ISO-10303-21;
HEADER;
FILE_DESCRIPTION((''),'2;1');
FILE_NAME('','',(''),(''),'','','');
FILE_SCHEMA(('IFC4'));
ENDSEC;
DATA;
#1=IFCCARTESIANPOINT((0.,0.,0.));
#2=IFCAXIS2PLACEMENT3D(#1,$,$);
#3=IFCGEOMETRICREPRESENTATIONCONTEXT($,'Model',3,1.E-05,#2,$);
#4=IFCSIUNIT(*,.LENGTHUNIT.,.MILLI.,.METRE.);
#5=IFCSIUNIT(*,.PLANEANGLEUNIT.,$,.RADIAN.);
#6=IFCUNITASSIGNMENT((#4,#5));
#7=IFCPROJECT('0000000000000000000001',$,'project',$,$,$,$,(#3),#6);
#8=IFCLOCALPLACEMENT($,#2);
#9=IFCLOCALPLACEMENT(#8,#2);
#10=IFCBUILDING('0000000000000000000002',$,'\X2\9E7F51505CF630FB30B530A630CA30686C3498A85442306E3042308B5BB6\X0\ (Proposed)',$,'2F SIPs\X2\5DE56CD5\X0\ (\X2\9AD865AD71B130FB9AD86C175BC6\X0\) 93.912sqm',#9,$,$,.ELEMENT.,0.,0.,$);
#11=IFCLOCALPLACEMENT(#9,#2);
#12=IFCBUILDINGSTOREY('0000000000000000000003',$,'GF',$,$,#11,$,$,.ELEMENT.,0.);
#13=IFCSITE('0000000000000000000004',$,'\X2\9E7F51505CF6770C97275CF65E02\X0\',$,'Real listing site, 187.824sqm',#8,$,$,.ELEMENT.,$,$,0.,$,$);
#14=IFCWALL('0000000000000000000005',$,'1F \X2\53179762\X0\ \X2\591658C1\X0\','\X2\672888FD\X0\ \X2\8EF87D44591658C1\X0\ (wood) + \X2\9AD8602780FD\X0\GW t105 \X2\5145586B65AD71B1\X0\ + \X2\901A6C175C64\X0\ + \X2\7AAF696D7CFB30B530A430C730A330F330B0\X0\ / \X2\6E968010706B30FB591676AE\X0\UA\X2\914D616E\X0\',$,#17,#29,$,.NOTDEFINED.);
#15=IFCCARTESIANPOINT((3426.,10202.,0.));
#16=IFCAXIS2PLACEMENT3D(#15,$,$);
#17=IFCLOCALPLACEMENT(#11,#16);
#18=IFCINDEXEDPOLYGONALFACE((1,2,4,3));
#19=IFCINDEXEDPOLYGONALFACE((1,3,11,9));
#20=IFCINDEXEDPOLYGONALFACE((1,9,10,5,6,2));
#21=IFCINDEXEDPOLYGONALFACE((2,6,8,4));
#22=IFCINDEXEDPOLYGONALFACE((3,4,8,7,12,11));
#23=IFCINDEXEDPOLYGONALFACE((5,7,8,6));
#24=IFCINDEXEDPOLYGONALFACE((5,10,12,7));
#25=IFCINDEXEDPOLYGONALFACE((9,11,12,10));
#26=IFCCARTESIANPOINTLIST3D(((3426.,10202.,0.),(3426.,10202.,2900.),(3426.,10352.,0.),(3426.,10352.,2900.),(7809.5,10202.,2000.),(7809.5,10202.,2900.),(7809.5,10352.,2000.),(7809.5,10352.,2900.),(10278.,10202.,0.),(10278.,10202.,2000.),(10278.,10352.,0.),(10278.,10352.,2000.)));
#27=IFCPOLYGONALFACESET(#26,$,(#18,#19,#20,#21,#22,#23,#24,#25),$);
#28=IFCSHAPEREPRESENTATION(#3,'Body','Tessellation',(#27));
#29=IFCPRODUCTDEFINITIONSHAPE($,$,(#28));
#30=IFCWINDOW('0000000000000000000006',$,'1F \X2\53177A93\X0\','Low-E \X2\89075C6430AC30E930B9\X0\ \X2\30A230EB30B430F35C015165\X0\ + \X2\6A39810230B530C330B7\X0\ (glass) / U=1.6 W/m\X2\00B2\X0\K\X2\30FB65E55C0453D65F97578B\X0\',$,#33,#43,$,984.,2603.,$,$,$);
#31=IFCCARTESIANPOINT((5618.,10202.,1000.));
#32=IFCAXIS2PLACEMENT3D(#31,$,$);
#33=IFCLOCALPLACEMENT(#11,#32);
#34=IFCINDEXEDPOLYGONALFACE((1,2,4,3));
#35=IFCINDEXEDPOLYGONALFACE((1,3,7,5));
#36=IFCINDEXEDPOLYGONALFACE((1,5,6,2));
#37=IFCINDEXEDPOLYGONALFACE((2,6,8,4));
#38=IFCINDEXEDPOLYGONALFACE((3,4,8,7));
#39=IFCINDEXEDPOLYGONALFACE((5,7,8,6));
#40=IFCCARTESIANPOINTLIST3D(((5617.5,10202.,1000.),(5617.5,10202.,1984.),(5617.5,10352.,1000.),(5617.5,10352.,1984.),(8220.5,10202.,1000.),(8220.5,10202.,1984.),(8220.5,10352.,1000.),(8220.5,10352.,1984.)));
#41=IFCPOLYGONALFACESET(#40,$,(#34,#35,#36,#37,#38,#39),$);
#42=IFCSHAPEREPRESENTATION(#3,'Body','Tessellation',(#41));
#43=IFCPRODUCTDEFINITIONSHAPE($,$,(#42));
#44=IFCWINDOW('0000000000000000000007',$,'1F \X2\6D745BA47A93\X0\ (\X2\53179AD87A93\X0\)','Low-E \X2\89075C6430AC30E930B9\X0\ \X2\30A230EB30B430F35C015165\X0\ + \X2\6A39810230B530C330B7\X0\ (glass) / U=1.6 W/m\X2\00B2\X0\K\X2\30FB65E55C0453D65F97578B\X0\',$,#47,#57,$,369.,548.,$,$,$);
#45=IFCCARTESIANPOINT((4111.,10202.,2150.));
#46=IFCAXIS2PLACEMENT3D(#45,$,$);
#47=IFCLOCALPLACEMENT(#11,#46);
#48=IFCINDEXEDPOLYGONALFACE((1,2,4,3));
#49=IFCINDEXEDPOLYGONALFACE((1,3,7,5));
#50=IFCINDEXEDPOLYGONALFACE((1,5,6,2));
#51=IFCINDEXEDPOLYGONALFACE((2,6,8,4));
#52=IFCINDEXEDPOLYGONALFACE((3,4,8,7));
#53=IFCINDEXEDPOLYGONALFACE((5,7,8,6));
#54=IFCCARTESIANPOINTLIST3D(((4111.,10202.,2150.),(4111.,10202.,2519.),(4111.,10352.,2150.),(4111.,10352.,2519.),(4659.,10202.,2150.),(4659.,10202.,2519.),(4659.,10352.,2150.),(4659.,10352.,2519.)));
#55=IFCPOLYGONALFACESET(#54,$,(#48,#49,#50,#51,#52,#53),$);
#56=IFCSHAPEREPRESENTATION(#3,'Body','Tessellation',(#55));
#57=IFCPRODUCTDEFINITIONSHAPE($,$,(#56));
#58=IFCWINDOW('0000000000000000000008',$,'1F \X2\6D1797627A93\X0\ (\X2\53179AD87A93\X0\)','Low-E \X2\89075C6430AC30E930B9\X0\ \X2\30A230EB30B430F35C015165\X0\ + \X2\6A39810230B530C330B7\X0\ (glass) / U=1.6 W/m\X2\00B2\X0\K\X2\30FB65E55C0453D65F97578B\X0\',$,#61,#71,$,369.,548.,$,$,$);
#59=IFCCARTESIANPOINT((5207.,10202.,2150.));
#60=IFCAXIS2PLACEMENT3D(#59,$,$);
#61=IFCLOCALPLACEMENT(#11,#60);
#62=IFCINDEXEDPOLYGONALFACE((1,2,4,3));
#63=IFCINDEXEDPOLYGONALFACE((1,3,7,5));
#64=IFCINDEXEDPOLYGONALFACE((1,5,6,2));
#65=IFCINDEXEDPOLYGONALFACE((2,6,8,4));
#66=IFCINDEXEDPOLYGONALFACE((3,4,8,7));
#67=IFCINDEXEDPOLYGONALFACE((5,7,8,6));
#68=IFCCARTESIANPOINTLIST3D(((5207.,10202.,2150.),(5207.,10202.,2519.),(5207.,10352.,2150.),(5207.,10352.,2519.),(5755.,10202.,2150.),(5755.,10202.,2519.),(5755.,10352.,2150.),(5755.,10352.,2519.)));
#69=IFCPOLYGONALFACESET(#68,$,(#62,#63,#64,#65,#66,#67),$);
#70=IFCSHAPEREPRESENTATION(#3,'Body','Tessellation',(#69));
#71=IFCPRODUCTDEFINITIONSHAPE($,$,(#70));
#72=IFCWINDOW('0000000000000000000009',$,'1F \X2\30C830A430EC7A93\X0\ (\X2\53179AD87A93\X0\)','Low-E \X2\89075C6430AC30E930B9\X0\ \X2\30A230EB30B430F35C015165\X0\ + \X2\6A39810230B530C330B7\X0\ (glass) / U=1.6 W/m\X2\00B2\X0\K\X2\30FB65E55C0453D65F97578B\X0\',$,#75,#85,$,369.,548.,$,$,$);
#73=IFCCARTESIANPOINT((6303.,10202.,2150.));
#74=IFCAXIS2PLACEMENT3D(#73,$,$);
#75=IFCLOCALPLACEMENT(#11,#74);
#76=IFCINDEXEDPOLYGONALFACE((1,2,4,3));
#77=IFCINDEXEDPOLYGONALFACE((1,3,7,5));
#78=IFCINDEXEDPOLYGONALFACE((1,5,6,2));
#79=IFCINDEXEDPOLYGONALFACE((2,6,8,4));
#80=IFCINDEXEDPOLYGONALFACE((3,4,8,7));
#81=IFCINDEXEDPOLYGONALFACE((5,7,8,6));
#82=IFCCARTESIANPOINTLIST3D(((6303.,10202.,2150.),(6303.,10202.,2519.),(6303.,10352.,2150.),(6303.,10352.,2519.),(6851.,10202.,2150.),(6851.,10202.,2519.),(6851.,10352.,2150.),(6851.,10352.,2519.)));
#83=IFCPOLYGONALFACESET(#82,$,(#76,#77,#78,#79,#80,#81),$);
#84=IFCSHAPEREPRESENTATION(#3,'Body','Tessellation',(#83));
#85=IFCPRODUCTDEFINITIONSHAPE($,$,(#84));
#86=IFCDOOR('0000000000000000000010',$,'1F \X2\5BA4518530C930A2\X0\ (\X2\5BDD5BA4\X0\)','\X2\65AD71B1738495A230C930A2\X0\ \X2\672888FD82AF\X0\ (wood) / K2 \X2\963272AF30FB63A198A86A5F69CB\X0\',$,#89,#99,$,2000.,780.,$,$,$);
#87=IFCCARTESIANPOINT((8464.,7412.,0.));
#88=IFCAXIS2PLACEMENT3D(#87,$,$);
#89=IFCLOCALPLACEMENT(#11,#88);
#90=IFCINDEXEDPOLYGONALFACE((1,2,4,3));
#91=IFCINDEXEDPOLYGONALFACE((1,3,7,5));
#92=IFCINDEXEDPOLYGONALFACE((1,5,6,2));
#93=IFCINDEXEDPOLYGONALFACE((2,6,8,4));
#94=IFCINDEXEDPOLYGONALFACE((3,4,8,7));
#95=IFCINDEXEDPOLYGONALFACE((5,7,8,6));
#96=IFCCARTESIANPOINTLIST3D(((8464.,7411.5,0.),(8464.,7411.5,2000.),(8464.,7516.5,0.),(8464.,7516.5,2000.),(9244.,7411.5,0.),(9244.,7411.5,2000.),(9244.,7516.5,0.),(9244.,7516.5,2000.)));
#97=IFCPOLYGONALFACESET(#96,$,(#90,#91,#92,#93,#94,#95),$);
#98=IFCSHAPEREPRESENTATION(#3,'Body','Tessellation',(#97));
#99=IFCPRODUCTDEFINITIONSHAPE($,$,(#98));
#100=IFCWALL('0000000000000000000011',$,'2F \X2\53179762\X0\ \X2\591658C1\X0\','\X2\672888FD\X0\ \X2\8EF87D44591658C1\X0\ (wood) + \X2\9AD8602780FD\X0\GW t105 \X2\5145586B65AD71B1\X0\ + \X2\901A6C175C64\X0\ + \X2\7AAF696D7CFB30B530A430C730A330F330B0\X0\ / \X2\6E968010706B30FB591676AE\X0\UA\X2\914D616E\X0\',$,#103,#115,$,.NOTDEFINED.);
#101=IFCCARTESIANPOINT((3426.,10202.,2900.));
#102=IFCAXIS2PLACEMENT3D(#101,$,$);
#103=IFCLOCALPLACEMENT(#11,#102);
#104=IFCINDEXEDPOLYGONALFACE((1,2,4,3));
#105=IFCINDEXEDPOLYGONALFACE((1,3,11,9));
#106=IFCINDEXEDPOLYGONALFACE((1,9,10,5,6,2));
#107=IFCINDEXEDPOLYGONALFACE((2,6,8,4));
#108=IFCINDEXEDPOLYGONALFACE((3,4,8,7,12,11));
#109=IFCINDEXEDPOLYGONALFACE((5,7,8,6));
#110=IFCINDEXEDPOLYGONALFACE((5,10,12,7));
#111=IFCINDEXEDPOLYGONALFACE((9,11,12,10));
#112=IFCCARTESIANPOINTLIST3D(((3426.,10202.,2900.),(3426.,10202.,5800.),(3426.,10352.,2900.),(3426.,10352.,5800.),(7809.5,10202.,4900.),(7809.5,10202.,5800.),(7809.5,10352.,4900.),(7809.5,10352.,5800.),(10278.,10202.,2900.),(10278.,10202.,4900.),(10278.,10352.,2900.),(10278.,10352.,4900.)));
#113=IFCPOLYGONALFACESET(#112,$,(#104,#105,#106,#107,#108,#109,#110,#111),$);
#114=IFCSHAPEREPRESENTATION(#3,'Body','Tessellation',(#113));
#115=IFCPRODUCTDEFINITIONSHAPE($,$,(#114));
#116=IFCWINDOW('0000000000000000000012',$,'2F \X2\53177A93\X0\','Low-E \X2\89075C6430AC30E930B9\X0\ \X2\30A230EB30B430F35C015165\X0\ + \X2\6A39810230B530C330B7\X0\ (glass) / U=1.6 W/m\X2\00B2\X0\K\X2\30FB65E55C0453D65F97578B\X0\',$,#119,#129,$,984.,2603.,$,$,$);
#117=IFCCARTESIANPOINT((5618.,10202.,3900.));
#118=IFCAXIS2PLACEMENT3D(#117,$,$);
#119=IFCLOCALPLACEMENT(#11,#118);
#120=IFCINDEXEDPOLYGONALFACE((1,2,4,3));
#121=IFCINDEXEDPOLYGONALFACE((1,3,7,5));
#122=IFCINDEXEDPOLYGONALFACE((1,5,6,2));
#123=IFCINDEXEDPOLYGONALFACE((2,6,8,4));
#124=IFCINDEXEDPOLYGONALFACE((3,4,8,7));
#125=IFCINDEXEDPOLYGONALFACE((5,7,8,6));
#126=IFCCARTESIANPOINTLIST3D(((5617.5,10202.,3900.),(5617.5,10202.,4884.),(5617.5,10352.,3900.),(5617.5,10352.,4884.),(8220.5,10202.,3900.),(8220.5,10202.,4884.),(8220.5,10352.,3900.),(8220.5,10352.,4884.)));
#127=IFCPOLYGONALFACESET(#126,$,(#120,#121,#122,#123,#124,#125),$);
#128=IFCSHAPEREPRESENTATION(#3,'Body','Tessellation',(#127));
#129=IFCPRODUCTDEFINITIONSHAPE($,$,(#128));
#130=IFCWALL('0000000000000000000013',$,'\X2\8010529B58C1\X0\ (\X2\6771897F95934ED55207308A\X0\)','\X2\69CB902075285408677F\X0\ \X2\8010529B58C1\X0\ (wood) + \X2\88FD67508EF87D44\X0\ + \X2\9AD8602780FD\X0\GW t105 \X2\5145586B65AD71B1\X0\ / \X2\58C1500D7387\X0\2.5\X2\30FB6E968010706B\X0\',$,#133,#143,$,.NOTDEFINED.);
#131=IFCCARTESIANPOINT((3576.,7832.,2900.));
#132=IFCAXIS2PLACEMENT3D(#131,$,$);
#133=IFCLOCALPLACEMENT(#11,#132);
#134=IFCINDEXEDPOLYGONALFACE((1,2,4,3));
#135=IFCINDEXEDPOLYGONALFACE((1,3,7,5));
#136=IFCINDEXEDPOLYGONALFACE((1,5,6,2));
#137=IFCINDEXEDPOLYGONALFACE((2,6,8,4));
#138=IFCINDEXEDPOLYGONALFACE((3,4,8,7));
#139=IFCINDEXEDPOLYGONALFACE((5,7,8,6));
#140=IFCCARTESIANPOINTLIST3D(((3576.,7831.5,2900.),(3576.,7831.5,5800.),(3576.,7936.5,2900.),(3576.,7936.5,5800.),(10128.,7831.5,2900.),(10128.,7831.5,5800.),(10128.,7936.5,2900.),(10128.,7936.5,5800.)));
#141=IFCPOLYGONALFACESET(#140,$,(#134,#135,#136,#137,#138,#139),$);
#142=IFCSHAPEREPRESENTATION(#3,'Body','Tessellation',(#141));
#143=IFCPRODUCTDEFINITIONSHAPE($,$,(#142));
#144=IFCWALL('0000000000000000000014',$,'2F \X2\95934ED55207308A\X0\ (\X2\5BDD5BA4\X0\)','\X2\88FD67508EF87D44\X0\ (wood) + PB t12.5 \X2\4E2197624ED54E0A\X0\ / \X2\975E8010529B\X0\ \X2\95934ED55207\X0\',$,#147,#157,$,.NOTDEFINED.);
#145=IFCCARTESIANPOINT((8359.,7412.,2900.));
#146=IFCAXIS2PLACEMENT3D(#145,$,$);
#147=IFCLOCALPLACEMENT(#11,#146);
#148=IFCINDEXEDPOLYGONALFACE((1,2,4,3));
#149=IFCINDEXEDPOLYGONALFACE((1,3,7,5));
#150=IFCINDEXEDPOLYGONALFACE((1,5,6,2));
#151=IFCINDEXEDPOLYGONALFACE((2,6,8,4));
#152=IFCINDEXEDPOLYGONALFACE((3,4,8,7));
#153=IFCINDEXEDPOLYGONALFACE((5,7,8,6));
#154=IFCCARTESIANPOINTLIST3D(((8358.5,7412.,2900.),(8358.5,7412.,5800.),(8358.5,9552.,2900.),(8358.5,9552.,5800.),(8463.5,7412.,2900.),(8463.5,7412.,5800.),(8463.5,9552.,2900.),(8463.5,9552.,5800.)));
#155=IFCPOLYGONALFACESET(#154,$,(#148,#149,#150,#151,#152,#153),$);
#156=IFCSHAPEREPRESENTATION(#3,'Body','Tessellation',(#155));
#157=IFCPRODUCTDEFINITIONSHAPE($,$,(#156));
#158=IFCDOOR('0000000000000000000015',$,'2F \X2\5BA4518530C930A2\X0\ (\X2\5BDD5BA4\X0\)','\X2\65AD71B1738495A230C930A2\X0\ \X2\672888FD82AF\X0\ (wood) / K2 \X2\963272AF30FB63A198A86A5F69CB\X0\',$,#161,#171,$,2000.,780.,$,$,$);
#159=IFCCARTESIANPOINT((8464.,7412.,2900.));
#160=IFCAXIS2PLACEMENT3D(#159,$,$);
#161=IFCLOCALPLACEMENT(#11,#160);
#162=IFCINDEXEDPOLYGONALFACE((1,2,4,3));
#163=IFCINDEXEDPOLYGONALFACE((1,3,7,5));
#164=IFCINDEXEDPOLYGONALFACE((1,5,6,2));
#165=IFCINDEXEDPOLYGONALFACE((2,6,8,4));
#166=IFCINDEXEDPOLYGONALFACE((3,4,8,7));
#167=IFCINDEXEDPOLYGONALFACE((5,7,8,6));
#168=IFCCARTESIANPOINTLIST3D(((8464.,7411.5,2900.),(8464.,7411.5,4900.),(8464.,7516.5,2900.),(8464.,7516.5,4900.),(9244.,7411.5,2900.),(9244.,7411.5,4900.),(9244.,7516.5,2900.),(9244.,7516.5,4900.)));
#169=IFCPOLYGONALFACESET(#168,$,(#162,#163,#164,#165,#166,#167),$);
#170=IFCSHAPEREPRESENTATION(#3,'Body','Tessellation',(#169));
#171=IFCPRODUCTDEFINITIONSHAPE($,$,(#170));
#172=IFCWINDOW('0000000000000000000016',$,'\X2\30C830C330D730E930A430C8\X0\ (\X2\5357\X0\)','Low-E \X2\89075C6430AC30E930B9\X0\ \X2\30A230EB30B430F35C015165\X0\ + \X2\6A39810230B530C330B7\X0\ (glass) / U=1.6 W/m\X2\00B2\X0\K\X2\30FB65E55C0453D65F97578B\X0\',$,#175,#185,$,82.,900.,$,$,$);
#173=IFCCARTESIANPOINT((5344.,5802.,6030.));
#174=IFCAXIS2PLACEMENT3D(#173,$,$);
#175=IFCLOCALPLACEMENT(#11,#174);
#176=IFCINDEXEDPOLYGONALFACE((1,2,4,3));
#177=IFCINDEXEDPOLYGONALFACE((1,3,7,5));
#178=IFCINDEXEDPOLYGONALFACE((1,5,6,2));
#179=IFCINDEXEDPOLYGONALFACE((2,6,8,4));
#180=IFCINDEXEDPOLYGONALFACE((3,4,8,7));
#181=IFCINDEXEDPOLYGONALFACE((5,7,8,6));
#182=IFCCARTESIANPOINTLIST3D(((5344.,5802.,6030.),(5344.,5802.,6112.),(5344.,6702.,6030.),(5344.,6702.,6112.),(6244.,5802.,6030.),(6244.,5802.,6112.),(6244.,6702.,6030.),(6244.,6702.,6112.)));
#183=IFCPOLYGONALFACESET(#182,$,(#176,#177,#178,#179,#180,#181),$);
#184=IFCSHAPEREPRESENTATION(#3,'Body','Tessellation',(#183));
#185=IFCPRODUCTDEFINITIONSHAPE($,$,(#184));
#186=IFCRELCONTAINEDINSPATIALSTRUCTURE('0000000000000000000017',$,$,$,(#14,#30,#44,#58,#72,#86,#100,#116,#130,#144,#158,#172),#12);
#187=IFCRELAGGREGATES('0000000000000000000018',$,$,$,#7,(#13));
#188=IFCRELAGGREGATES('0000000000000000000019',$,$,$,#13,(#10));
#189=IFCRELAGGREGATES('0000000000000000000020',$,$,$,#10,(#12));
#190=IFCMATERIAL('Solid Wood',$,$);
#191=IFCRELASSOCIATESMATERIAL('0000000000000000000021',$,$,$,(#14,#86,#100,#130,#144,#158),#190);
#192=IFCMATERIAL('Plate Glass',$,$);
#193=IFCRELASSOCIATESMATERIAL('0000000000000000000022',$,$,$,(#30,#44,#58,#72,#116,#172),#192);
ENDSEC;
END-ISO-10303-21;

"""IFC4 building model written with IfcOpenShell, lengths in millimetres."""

from ifc_helpers import new_model, si_unit, frame, frame_2d, origin, place, context, project, spatial, rectangle, extrude, material, element, fill, save


model = new_model("IFC4")

# Units and contexts
model_context = context("Model", 3, precision=1e-05, world=origin())
ifc_project = project(units=[si_unit("LENGTHUNIT", "METRE", prefix="MILLI"), si_unit("PLANEANGLEUNIT", "RADIAN")], contexts=[model_context])

# Site, building, storey
site_placement = place(None, origin())
site = spatial("IfcSite", under=ifc_project, at=site_placement, Name="鹿児島県霧島市", ObjectType="Real listing site, 187.824sqm", CompositionType="ELEMENT", RefElevation=0.0)
building_placement = place(site_placement, origin())
building = spatial("IfcBuilding", under=site, at=building_placement, Name="鹿児島・サウナと水風呂のある家 (Proposed)", ObjectType="2F SIPs工法 (高断熱・高気密) 93.912sqm", CompositionType="ELEMENT", ElevationOfRefHeight=0.0, ElevationOfTerrain=0.0)
storey_placement = place(building_placement, origin())
storey = spatial("IfcBuildingStorey", under=building, at=storey_placement, Name="GF", CompositionType="ELEMENT", Elevation=0.0)

# Wall, openings, windows
ifc_material_1 = material(Name="Solid Wood")
wall_1_placement = place(storey_placement, frame((3426.0, 10202.0, 0.0)))
wall_1 = element("IfcWall", 1, at=wall_1_placement, inside=storey, material=ifc_material_1, Name="1F 北面 外壁", Description="木製 軸組外壁 (wood) + 高性能GW t105 充填断熱 + 通気層 + 窯業系サイディング / 準耐火・外皮UA配慮", PredefinedType="NOTDEFINED", context=model_context, shape_type="SweptSolid", body=[
    extrude(rectangle(XDim=6852.0, YDim=150.0, at=frame_2d((3426.0, 75.0))), frame((3426.0, 10202.0, 0.0)), (0.0, 0.0, 1.0), 2900.0),
])
opening_1_placement = place(storey_placement, frame((5618.0, 10202.0, 1000.0)))
opening_1 = element("IfcOpeningElement", 2, at=opening_1_placement, cuts=wall_1, PredefinedType="NOTDEFINED", context=model_context, shape_type="SweptSolid", body=[
    extrude(rectangle(XDim=2603.0, YDim=150.0, at=frame_2d((1301.0, 75.0))), frame((5618.0, 10202.0, 1000.0)), (0.0, 0.0, 1.0), 984.0),
])
opening_2_placement = place(storey_placement, frame((4111.0, 10202.0, 2150.0)))
opening_2 = element("IfcOpeningElement", 3, at=opening_2_placement, cuts=wall_1, PredefinedType="NOTDEFINED", context=model_context, shape_type="SweptSolid", body=[
    extrude(rectangle(XDim=548.0, YDim=150.0, at=frame_2d((274.0, 75.0))), frame((4111.0, 10202.0, 2150.0)), (0.0, 0.0, 1.0), 369.0),
])
opening_3_placement = place(storey_placement, frame((5207.0, 10202.0, 2150.0)))
opening_3 = element("IfcOpeningElement", 4, at=opening_3_placement, cuts=wall_1, PredefinedType="NOTDEFINED", context=model_context, shape_type="SweptSolid", body=[
    extrude(rectangle(XDim=548.0, YDim=150.0, at=frame_2d((274.0, 75.0))), frame((5207.0, 10202.0, 2150.0)), (0.0, 0.0, 1.0), 369.0),
])
opening_4_placement = place(storey_placement, frame((6303.0, 10202.0, 2150.0)))
opening_4 = element("IfcOpeningElement", 5, at=opening_4_placement, cuts=wall_1, PredefinedType="NOTDEFINED", context=model_context, shape_type="SweptSolid", body=[
    extrude(rectangle(XDim=548.0, YDim=150.0, at=frame_2d((274.0, 75.0))), frame((6303.0, 10202.0, 2150.0)), (0.0, 0.0, 1.0), 369.0),
])
ifc_material_2 = material(Name="Plate Glass")
window_1_placement = place(storey_placement, frame((5618.0, 10202.0, 1000.0)))
window_1 = element("IfcWindow", 6, at=window_1_placement, inside=storey, material=ifc_material_2, Name="1F 北窓", Description="Low-E 複層ガラス アルゴン封入 + 樹脂サッシ (glass) / U=1.6 W/m²K・日射取得型", OverallHeight=984.0, OverallWidth=2603.0, context=model_context, shape_type="SweptSolid", body=[
    extrude(rectangle(XDim=2603.0, YDim=150.0, at=frame_2d((1301.0, 75.0))), frame((5618.0, 10202.0, 1000.0)), (0.0, 0.0, 1.0), 984.0),
])
fill(opening_1, window_1)
window_2_placement = place(storey_placement, frame((4111.0, 10202.0, 2150.0)))
window_2 = element("IfcWindow", 7, at=window_2_placement, inside=storey, material=ifc_material_2, Name="1F 浴室窓 (北高窓)", Description="Low-E 複層ガラス アルゴン封入 + 樹脂サッシ (glass) / U=1.6 W/m²K・日射取得型", OverallHeight=369.0, OverallWidth=548.0, context=model_context, shape_type="SweptSolid", body=[
    extrude(rectangle(XDim=548.0, YDim=150.0, at=frame_2d((274.0, 75.0))), frame((4111.0, 10202.0, 2150.0)), (0.0, 0.0, 1.0), 369.0),
])
fill(opening_2, window_2)
window_3_placement = place(storey_placement, frame((5207.0, 10202.0, 2150.0)))
window_3 = element("IfcWindow", 8, at=window_3_placement, inside=storey, material=ifc_material_2, Name="1F 洗面窓 (北高窓)", Description="Low-E 複層ガラス アルゴン封入 + 樹脂サッシ (glass) / U=1.6 W/m²K・日射取得型", OverallHeight=369.0, OverallWidth=548.0, context=model_context, shape_type="SweptSolid", body=[
    extrude(rectangle(XDim=548.0, YDim=150.0, at=frame_2d((274.0, 75.0))), frame((5207.0, 10202.0, 2150.0)), (0.0, 0.0, 1.0), 369.0),
])
fill(opening_3, window_3)
window_4_placement = place(storey_placement, frame((6303.0, 10202.0, 2150.0)))
window_4 = element("IfcWindow", 9, at=window_4_placement, inside=storey, material=ifc_material_2, Name="1F トイレ窓 (北高窓)", Description="Low-E 複層ガラス アルゴン封入 + 樹脂サッシ (glass) / U=1.6 W/m²K・日射取得型", OverallHeight=369.0, OverallWidth=548.0, context=model_context, shape_type="SweptSolid", body=[
    extrude(rectangle(XDim=548.0, YDim=150.0, at=frame_2d((274.0, 75.0))), frame((6303.0, 10202.0, 2150.0)), (0.0, 0.0, 1.0), 369.0),
])
fill(opening_4, window_4)

# Door
door_1_placement = place(storey_placement, frame((8464.0, 7412.0, 0.0)))
element("IfcDoor", 10, at=door_1_placement, inside=storey, material=ifc_material_1, Name="1F 室内ドア (寝室)", Description="断熱玄関ドア 木製芯 (wood) / K2 防犯・採風機構", OverallHeight=2000.0, OverallWidth=780.0, context=model_context, shape_type="SweptSolid", body=[
    extrude(rectangle(XDim=780.0, YDim=105.0, at=frame_2d((390.0, 52.0))), frame((8464.0, 7412.0, 0.0)), (0.0, 0.0, 1.0), 2000.0),
])

# Wall, opening, window
wall_2_placement = place(storey_placement, frame((3426.0, 10202.0, 2900.0)))
wall_2 = element("IfcWall", 11, at=wall_2_placement, inside=storey, material=ifc_material_1, Name="2F 北面 外壁", Description="木製 軸組外壁 (wood) + 高性能GW t105 充填断熱 + 通気層 + 窯業系サイディング / 準耐火・外皮UA配慮", PredefinedType="NOTDEFINED", context=model_context, shape_type="SweptSolid", body=[
    extrude(rectangle(XDim=6852.0, YDim=150.0, at=frame_2d((3426.0, 75.0))), frame((3426.0, 10202.0, 2900.0)), (0.0, 0.0, 1.0), 2900.0),
])
opening_5_placement = place(storey_placement, frame((5618.0, 10202.0, 3900.0)))
opening_5 = element("IfcOpeningElement", 12, at=opening_5_placement, cuts=wall_2, PredefinedType="NOTDEFINED", context=model_context, shape_type="SweptSolid", body=[
    extrude(rectangle(XDim=2603.0, YDim=150.0, at=frame_2d((1301.0, 75.0))), frame((5618.0, 10202.0, 3900.0)), (0.0, 0.0, 1.0), 984.0),
])
window_5_placement = place(storey_placement, frame((5618.0, 10202.0, 3900.0)))
window_5 = element("IfcWindow", 13, at=window_5_placement, inside=storey, material=ifc_material_2, Name="2F 北窓", Description="Low-E 複層ガラス アルゴン封入 + 樹脂サッシ (glass) / U=1.6 W/m²K・日射取得型", OverallHeight=984.0, OverallWidth=2603.0, context=model_context, shape_type="SweptSolid", body=[
    extrude(rectangle(XDim=2603.0, YDim=150.0, at=frame_2d((1301.0, 75.0))), frame((5618.0, 10202.0, 3900.0)), (0.0, 0.0, 1.0), 984.0),
])
fill(opening_5, window_5)

# Walls
wall_3_placement = place(storey_placement, frame((3576.0, 7832.0, 2900.0)))
element("IfcWall", 14, at=wall_3_placement, inside=storey, material=ifc_material_1, Name="耐力壁 (東西間仕切り)", Description="構造用合板 耐力壁 (wood) + 製材軸組 + 高性能GW t105 充填断熱 / 壁倍率2.5・準耐火", PredefinedType="NOTDEFINED", context=model_context, shape_type="SweptSolid", body=[
    extrude(rectangle(XDim=6552.0, YDim=105.0, at=frame_2d((3276.0, 52.0))), frame((3576.0, 7832.0, 2900.0)), (0.0, 0.0, 1.0), 2900.0),
])
wall_4_placement = place(storey_placement, frame((8359.0, 7412.0, 2900.0)))
element("IfcWall", 15, at=wall_4_placement, inside=storey, material=ifc_material_1, Name="2F 間仕切り (寝室)", Description="製材軸組 (wood) + PB t12.5 両面仕上 / 非耐力 間仕切", PredefinedType="NOTDEFINED", context=model_context, shape_type="SweptSolid", body=[
    extrude(rectangle(XDim=105.0, YDim=2140.0, at=frame_2d((52.0, 1070.0))), frame((8359.0, 7412.0, 2900.0)), (0.0, 0.0, 1.0), 2900.0),
])

# Door
door_2_placement = place(storey_placement, frame((8464.0, 7412.0, 2900.0)))
element("IfcDoor", 16, at=door_2_placement, inside=storey, material=ifc_material_1, Name="2F 室内ドア (寝室)", Description="断熱玄関ドア 木製芯 (wood) / K2 防犯・採風機構", OverallHeight=2000.0, OverallWidth=780.0, context=model_context, shape_type="SweptSolid", body=[
    extrude(rectangle(XDim=780.0, YDim=105.0, at=frame_2d((390.0, 52.0))), frame((8464.0, 7412.0, 2900.0)), (0.0, 0.0, 1.0), 2000.0),
])

# Window
window_6_placement = place(storey_placement, frame((5344.0, 5802.0, 6030.0)))
element("IfcWindow", 17, at=window_6_placement, inside=storey, material=ifc_material_2, Name="トップライト (南)", Description="Low-E 複層ガラス アルゴン封入 + 樹脂サッシ (glass) / U=1.6 W/m²K・日射取得型", OverallHeight=82.0, OverallWidth=900.0, context=model_context, shape_type="SweptSolid", body=[
    extrude(rectangle(XDim=900.0, YDim=900.0, at=frame_2d((450.0, 450.0))), frame((5344.0, 5802.0, 6030.0)), (0.0, 0.0, 1.0), 82.0),
])

save(model, "model.ifc")
